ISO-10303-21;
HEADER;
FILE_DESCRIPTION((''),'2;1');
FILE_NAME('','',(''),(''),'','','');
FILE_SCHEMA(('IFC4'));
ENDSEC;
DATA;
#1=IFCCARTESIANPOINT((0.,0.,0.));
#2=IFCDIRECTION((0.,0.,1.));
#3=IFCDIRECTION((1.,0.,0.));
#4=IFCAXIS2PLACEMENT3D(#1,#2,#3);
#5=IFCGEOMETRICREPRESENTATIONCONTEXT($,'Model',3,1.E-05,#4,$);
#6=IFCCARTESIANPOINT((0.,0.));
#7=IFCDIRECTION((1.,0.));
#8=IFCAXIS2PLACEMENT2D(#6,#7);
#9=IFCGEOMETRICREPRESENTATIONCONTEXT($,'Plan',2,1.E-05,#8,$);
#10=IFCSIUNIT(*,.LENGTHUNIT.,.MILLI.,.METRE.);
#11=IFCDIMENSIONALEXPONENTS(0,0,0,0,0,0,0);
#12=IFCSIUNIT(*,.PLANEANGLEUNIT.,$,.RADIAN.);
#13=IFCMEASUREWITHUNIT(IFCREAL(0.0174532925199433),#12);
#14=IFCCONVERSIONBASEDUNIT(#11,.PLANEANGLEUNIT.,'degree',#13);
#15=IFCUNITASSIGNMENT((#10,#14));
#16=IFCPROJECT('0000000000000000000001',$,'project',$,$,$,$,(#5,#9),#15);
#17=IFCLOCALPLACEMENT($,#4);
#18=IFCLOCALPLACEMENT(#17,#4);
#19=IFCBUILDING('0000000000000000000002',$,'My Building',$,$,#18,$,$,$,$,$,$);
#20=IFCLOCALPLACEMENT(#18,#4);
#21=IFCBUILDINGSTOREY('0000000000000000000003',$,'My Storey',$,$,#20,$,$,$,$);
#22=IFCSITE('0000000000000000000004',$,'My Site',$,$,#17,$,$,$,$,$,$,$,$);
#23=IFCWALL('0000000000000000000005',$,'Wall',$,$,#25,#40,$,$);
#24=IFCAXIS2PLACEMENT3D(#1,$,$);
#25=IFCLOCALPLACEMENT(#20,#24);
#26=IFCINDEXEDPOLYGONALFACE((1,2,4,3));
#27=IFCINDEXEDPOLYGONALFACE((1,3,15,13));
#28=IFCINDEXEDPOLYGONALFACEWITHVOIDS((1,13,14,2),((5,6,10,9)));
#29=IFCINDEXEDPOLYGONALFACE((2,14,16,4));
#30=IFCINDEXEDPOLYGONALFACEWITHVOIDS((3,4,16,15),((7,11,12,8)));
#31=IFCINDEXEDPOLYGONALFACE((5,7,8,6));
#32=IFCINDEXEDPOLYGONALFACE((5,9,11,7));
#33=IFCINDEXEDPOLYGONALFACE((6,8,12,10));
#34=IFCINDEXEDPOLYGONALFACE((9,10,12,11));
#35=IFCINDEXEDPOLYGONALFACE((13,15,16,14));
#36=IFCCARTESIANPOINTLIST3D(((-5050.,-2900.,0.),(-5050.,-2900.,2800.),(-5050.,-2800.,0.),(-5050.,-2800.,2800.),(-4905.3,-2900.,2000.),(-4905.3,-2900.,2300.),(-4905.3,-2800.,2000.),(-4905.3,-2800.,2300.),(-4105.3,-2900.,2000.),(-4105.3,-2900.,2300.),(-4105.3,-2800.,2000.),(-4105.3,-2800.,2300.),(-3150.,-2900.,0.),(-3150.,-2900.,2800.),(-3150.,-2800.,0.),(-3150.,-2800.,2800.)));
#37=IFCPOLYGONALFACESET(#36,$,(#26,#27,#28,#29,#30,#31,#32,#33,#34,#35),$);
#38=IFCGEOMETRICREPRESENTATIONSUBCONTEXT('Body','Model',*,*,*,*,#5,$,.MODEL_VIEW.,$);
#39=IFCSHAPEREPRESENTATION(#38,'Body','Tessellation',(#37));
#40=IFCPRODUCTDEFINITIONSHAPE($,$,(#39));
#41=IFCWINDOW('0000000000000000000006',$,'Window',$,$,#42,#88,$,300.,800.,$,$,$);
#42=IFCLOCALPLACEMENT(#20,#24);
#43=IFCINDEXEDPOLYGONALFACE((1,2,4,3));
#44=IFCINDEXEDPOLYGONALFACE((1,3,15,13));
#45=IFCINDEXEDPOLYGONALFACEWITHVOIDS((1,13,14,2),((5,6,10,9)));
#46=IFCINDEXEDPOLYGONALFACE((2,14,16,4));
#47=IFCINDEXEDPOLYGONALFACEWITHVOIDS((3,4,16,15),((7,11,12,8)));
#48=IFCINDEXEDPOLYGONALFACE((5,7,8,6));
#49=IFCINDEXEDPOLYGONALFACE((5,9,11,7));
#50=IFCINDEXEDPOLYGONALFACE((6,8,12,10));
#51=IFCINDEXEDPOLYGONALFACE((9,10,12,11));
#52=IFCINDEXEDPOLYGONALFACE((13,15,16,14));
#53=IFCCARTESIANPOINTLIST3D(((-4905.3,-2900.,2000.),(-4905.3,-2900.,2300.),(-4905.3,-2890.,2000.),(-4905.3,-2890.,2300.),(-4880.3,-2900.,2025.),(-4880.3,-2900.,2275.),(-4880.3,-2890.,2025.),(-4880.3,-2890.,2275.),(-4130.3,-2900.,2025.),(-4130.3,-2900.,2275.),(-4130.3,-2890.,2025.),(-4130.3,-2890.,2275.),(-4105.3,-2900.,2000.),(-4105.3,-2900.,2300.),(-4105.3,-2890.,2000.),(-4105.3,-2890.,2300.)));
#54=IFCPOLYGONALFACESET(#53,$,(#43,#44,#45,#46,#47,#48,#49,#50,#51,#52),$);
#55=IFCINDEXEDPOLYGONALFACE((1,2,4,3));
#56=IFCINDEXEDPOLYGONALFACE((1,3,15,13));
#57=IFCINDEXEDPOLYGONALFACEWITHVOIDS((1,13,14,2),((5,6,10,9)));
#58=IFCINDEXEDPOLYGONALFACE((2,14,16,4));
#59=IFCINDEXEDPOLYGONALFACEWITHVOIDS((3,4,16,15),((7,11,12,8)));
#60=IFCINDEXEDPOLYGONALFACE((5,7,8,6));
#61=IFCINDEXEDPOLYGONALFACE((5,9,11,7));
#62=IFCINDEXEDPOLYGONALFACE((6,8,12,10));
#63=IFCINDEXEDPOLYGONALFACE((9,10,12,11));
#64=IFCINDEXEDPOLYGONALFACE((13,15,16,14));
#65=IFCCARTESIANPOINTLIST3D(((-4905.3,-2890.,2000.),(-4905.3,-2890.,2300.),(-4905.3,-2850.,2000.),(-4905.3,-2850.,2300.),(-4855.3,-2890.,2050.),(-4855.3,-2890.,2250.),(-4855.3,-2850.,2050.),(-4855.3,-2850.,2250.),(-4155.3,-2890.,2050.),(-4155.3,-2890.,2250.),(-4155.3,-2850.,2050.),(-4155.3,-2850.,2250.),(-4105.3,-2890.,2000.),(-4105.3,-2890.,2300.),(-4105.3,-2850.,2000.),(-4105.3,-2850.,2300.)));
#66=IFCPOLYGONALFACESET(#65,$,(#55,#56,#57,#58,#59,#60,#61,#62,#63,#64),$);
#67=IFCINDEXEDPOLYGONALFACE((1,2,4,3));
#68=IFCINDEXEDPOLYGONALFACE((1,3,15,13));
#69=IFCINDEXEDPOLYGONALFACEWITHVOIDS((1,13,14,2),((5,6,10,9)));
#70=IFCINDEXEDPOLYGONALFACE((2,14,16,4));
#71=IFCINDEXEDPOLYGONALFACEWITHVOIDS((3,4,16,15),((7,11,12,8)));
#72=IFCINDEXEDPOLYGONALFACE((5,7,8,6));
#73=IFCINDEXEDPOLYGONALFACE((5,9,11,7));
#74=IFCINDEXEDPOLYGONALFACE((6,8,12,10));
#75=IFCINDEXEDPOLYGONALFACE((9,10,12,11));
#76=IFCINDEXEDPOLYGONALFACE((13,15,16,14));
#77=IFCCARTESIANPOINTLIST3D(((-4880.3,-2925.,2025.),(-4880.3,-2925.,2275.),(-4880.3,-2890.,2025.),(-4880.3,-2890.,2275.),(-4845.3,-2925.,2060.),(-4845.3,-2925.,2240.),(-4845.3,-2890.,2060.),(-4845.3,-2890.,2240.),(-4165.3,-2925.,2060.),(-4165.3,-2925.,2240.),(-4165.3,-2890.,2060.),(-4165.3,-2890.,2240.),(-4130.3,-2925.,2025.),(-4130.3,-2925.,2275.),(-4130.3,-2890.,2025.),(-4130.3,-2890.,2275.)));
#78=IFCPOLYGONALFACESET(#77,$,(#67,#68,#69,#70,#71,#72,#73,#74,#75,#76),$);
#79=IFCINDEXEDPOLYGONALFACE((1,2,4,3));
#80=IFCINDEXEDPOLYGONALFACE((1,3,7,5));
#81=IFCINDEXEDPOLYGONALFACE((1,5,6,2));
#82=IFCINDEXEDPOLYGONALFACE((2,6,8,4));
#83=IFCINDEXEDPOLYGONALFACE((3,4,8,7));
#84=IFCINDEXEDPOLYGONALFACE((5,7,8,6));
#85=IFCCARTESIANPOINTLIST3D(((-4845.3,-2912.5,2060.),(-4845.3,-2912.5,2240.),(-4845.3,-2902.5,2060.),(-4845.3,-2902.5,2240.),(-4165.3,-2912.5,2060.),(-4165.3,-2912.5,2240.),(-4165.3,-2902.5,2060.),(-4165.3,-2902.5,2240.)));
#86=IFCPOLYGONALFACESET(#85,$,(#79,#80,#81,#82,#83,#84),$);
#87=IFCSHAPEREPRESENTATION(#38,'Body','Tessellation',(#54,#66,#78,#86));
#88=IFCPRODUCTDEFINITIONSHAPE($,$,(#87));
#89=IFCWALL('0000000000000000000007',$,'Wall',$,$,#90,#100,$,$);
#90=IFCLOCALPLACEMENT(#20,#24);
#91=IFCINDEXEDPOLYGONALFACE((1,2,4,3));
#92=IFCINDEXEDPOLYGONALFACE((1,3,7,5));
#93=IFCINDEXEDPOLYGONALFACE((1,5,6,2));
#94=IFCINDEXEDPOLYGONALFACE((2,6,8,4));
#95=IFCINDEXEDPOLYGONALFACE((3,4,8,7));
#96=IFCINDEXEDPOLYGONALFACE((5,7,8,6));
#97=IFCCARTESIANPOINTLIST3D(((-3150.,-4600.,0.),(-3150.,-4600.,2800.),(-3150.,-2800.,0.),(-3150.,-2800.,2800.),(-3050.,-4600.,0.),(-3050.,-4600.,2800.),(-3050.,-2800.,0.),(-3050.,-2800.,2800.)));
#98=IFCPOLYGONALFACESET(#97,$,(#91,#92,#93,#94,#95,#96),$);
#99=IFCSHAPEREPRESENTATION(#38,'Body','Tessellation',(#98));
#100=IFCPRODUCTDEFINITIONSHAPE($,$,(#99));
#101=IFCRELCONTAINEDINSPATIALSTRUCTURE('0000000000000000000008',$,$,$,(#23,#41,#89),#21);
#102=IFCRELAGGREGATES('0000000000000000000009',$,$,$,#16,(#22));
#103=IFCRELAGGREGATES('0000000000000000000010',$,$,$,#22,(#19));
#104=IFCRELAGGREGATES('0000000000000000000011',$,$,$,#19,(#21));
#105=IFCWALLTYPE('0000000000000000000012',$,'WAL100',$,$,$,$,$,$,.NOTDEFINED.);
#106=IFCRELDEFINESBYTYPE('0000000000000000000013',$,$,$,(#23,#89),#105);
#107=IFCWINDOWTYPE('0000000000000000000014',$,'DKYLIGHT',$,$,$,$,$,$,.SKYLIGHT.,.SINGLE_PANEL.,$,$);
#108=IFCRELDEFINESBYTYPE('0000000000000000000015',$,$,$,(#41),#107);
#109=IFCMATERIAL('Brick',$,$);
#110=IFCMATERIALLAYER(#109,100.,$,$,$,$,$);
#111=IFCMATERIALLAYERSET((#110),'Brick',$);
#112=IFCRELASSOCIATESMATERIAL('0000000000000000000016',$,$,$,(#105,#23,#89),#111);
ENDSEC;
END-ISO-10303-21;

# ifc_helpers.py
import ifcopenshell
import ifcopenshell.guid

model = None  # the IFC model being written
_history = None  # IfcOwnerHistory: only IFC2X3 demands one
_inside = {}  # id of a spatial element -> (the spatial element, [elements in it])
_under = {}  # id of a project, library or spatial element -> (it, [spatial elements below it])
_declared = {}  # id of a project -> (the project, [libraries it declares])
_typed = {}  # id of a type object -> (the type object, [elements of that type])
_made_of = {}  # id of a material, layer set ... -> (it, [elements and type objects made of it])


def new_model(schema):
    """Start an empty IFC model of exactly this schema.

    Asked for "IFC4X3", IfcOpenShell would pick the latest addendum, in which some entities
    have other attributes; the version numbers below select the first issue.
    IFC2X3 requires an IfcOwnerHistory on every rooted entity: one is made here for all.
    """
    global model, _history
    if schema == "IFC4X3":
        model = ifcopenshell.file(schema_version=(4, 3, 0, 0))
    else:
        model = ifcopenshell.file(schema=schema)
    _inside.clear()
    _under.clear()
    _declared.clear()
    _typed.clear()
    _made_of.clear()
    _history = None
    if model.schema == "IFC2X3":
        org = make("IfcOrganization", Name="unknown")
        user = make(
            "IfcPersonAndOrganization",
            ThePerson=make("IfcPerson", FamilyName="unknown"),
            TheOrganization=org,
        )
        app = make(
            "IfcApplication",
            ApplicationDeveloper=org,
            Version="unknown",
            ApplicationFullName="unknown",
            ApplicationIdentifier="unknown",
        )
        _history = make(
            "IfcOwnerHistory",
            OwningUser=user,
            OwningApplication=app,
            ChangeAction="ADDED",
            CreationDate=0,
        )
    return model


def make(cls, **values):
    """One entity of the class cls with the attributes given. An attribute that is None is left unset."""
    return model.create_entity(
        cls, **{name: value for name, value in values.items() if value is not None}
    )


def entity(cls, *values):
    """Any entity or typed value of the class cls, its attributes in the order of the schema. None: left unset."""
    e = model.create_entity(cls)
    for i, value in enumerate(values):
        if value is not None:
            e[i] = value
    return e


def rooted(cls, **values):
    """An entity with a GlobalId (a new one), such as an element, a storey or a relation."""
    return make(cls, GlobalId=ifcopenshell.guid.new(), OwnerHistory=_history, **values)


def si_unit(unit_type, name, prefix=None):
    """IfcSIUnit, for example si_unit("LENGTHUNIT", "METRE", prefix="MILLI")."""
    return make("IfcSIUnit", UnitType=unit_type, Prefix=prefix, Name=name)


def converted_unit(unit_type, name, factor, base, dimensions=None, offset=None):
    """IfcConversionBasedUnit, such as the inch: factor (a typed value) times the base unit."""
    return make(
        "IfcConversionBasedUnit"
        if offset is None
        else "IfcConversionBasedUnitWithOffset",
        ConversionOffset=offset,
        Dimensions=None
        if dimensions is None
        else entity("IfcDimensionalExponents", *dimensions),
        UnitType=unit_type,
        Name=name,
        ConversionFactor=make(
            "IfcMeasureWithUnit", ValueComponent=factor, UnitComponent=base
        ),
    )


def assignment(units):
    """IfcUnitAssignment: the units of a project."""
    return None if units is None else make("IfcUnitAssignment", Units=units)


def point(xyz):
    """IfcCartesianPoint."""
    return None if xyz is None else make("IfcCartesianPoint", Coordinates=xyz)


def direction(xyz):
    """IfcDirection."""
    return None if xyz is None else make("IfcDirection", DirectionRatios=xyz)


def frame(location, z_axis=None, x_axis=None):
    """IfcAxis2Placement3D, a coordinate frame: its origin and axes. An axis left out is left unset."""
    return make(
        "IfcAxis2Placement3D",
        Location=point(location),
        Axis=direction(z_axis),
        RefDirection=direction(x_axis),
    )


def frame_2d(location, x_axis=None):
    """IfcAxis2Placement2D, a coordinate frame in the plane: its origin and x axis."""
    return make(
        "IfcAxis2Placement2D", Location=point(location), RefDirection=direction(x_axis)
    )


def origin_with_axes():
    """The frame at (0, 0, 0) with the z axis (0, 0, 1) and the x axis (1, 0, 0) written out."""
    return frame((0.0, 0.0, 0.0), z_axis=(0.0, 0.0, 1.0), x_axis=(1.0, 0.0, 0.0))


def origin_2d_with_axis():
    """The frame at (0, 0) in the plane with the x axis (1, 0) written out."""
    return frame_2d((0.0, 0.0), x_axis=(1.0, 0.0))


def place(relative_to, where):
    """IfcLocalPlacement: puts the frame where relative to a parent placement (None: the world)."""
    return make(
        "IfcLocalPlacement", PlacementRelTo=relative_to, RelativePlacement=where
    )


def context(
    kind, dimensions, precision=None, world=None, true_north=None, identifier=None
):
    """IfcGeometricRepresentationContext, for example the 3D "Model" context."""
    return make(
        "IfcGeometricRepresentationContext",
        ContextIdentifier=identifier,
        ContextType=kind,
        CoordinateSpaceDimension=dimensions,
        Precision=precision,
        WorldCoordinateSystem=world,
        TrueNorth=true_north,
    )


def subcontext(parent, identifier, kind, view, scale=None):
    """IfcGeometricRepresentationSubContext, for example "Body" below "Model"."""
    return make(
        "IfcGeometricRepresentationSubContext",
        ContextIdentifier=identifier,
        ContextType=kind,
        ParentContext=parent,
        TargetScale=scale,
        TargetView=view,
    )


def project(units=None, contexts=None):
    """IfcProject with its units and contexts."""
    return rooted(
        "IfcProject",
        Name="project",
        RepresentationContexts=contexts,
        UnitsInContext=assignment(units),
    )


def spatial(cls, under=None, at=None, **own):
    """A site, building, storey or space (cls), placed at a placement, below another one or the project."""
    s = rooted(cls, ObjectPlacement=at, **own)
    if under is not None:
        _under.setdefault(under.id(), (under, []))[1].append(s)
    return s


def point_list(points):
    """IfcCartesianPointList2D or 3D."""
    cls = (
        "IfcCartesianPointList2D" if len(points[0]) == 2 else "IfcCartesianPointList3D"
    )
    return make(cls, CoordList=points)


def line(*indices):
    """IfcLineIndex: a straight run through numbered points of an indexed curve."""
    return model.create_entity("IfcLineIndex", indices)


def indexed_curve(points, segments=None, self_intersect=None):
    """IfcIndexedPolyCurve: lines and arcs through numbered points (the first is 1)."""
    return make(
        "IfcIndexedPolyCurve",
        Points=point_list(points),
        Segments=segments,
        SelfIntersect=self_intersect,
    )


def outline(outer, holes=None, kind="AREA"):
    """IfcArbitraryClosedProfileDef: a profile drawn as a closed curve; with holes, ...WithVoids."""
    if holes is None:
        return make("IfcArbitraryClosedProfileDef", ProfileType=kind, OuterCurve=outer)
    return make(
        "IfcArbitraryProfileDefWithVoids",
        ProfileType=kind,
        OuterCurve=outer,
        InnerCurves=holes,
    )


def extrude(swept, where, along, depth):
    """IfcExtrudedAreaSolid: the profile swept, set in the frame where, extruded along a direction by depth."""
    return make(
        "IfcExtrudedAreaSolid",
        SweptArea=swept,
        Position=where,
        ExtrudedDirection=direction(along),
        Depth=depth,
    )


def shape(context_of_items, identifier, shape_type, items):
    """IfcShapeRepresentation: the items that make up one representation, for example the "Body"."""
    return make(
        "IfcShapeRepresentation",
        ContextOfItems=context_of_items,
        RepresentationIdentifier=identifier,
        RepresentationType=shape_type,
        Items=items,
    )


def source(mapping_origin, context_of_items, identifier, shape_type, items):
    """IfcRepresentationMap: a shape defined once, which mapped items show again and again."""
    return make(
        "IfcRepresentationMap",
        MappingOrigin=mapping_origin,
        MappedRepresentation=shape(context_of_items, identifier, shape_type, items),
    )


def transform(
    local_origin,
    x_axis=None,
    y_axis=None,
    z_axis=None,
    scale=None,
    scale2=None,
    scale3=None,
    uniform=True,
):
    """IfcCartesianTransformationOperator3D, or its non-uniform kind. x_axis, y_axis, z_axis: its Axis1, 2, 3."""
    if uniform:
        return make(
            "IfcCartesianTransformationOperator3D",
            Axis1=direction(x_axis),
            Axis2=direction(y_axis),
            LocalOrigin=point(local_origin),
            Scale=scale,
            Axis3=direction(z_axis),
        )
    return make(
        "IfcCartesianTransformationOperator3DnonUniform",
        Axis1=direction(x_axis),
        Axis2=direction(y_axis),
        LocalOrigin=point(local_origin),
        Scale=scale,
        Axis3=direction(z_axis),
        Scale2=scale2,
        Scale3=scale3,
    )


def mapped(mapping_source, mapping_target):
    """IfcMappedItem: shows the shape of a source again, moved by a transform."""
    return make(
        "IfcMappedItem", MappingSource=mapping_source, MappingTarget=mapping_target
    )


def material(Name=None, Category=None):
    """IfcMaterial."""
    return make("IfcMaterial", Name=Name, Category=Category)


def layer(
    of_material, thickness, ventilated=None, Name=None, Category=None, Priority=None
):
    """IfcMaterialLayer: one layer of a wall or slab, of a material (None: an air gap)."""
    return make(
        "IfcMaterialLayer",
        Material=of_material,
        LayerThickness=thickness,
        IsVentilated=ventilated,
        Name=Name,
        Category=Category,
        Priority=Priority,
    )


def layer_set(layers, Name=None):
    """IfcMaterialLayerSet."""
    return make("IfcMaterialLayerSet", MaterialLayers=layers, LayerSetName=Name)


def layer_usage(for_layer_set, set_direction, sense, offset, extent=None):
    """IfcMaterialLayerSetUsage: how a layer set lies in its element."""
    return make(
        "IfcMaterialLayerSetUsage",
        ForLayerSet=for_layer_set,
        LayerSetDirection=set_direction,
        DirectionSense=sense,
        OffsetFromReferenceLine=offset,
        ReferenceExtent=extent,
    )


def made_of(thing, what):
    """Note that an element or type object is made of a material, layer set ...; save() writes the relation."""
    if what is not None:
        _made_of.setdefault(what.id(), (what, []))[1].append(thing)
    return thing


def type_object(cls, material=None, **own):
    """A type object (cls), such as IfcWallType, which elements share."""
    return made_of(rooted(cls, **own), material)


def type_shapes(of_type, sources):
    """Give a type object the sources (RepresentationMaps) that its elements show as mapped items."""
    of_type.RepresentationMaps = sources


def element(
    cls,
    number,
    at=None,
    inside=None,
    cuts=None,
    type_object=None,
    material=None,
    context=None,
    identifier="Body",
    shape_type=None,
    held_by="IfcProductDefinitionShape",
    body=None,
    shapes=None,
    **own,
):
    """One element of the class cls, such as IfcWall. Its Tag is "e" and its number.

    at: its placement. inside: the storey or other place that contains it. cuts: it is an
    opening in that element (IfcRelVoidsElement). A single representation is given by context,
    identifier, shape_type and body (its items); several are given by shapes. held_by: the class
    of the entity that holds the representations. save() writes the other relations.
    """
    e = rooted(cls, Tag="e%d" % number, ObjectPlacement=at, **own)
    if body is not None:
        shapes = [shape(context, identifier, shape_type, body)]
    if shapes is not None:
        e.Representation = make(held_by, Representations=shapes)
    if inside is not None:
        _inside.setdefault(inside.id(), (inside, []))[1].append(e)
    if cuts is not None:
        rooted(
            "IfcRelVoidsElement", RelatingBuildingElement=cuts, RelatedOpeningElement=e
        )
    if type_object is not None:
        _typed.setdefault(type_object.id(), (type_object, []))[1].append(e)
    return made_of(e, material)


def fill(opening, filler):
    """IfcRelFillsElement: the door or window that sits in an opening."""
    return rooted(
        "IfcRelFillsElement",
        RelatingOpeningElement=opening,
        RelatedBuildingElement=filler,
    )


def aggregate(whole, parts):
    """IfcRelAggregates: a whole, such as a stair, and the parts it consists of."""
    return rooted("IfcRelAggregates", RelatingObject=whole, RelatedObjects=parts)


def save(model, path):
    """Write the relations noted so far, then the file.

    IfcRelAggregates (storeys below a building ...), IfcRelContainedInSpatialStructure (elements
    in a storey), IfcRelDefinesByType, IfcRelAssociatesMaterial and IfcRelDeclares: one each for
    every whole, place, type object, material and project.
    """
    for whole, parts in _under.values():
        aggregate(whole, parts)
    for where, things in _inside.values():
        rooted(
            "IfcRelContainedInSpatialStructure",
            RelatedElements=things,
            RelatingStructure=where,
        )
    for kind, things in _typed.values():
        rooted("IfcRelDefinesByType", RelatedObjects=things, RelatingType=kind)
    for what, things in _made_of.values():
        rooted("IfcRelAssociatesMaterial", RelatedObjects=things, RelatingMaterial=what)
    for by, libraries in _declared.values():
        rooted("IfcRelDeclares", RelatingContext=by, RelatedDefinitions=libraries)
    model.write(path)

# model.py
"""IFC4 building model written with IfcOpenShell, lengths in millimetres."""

from ifc_helpers import new_model, entity, si_unit, converted_unit, frame, origin_with_axes, origin_2d_with_axis, place, context, subcontext, project, spatial, line, indexed_curve, outline, extrude, shape, source, transform, mapped, material, layer, layer_set, layer_usage, type_object, type_shapes, element, fill, save


model = new_model("IFC4")

# Units and contexts
model_context = context("Model", 3, precision=1e-05, world=origin_with_axes())
plan_context = context("Plan", 2, precision=1e-05, world=origin_2d_with_axis())
body_context_1 = subcontext(model_context, "Body", "Model", "MODEL_VIEW")
body_context_2 = subcontext(plan_context, "Body", "Plan", "PLAN_VIEW")
ifc_project = project(units=[si_unit("LENGTHUNIT", "METRE", prefix="MILLI"), converted_unit("PLANEANGLEUNIT", "degree", entity("IfcReal", 0.0174532925199433), si_unit("PLANEANGLEUNIT", "RADIAN"), dimensions=[0, 0, 0, 0, 0, 0, 0])], contexts=[model_context, plan_context])

# Site, building, storey
site_placement = place(None, origin_with_axes())
site = spatial("IfcSite", under=ifc_project, at=site_placement, Name="My Site")
building_placement = place(site_placement, origin_with_axes())
building = spatial("IfcBuilding", under=site, at=building_placement, Name="My Building")
storey_placement = place(building_placement, origin_with_axes())
storey = spatial("IfcBuildingStorey", under=building, at=storey_placement, Name="My Storey")

# Shared definitions
ifc_material = material(Name="Brick")
ifc_layer_1 = layer(ifc_material, 100.0)
ifc_layer_set_1 = layer_set([ifc_layer_1], Name="Brick")
wall_type = type_object("IfcWallType", Name="WAL100", PredefinedType="NOTDEFINED", material=ifc_layer_set_1)

# Wall, opening, window
ifc_layer_usage_1 = layer_usage(ifc_layer_set_1, "AXIS2", "POSITIVE", 0.0)
wall_1_placement = place(storey_placement, frame((-3150.0, -2800.0, 0.0), z_axis=(0.0, 0.0, 1.0), x_axis=(-1.0, 0.000001, 0.0)))
wall_1 = element("IfcWall", 1, at=wall_1_placement, inside=storey, type_object=wall_type, material=ifc_layer_usage_1, Name="Wall", context=body_context_1, shape_type="SweptSolid", body=[
    extrude(outline(indexed_curve([(0.0, 0.0), (0.0, 100.0), (1900.0, 100.0), (1900.0, 0.0), (0.0, 0.0)], self_intersect=False)), origin_with_axes(), (0.0, 0.0, 1.0), 2800.0),
])
shared_shape_1 = source(origin_with_axes(), body_context_1, "Body", "SweptSolid", [
    extrude(outline(indexed_curve([(0.0, 0.0), (800.0, 0.0), (800.0, 300.0), (0.0, 300.0)], segments=[line(1, 2, 3, 4, 1)])), frame((0.0, -100.0, 0.0), z_axis=(0.0, -1.0, 0.0), x_axis=(1.0, 0.0, 0.0)), (0.0, 0.0, -1.0), 300.0),
])
opening_1_placement = place(wall_1_placement, frame((955.4, 0.0, 2000.0), z_axis=(0.0, 0.0, 1.0), x_axis=(1.0, 0.0, 0.0)))
opening_1 = element("IfcOpeningElement", 2, at=opening_1_placement, cuts=wall_1, PredefinedType="OPENING", context=body_context_1, shape_type="MappedRepresentation", body=[
    mapped(shared_shape_1, transform((0.0, 0.0, 0.0), x_axis=(1.0, 0.0, 0.0), y_axis=(0.0, 1.0, 0.0), z_axis=(0.0, 0.0, 1.0), scale=1.0)),
])
window_type_1 = type_object("IfcWindowType", Name="DKYLIGHT", PartitioningType="SINGLE_PANEL", PredefinedType="SKYLIGHT")
shared_shape_2 = source(origin_with_axes(), body_context_1, "Body", "SweptSolid", [
    extrude(outline(indexed_curve([(0.0, 0.0), (800.0, 0.0), (800.0, 300.0), (0.0, 300.0)], segments=[line(1, 2, 3, 4, 1)]), holes=[indexed_curve([(25.0, 25.0), (775.0, 25.0), (775.0, 275.0), (25.0, 275.0)], segments=[line(1, 2, 3, 4, 1)])]), frame((0.0, 90.0, 0.0), z_axis=(0.0, -1.0, 0.0), x_axis=(1.0, 0.0, 0.0)), (0.0, 0.0, -1.0), 10.0),
    extrude(outline(indexed_curve([(0.0, 0.0), (800.0, 0.0), (800.0, 300.0), (0.0, 300.0)], segments=[line(1, 2, 3, 4, 1)]), holes=[indexed_curve([(50.0, 50.0), (750.0, 50.0), (750.0, 250.0), (50.0, 250.0)], segments=[line(1, 2, 3, 4, 1)])]), frame((0.0, 50.0, 0.0), z_axis=(0.0, -1.0, 0.0), x_axis=(1.0, 0.0, 0.0)), (0.0, 0.0, -1.0), 40.0),
    extrude(outline(indexed_curve([(0.0, 0.0), (750.0, 0.0), (750.0, 250.0), (0.0, 250.0)], segments=[line(1, 2, 3, 4, 1)]), holes=[indexed_curve([(35.0, 35.0), (715.0, 35.0), (715.0, 215.0), (35.0, 215.0)], segments=[line(1, 2, 3, 4, 1)])]), frame((25.0, 90.0, 25.0), z_axis=(0.0, -1.0, 0.0), x_axis=(1.0, 0.0, 0.0)), (0.0, 0.0, -1.0), 35.0),
    extrude(outline(indexed_curve([(35.0, 35.0), (715.0, 35.0), (715.0, 215.0), (35.0, 215.0)], segments=[line(1, 2, 3, 4, 1)])), frame((25.0, 102.5, 25.0), z_axis=(0.0, -1.0, 0.0), x_axis=(1.0, 0.0, 0.0)), (0.0, 0.0, -1.0), 10.0),
])
shared_shape_3 = source(origin_with_axes(), body_context_2, "Body", "Curve2D", [
    entity("IfcIndexedPolyCurve", entity("IfcCartesianPointList2D", [[50.0, 50.0], [750.0, 50.0]])),
    entity("IfcIndexedPolyCurve", entity("IfcCartesianPointList2D", [[0.0, 100.0], [25.0, 100.0], [25.0, 90.0], [50.0, 90.0], [50.0, 50.0], [0.0, 50.0]]), [entity("IfcLineIndex", [1, 2, 3, 4, 5, 6, 1])]),
    entity("IfcIndexedPolyCurve", entity("IfcCartesianPointList2D", [[800.0, 100.0], [775.0, 100.0], [775.0, 90.0], [750.0, 90.0], [750.0, 50.0], [800.0, 50.0]]), [entity("IfcLineIndex", [1, 2, 3, 4, 5, 6, 1])]),
    entity("IfcIndexedPolyCurve", entity("IfcCartesianPointList2D", [[25.0, 90.0], [60.0, 90.0], [60.0, 125.0], [25.0, 125.0]]), [entity("IfcLineIndex", [1, 2, 3, 4, 1])]),
    entity("IfcIndexedPolyCurve", entity("IfcCartesianPointList2D", [[775.0, 90.0], [740.0, 90.0], [740.0, 125.0], [775.0, 125.0]]), [entity("IfcLineIndex", [1, 2, 3, 4, 1])]),
    entity("IfcIndexedPolyCurve", entity("IfcCartesianPointList2D", [[60.0, 90.0], [740.0, 90.0]])),
    entity("IfcIndexedPolyCurve", entity("IfcCartesianPointList2D", [[60.0, 125.0], [740.0, 125.0]])),
    entity("IfcIndexedPolyCurve", entity("IfcCartesianPointList2D", [[60.0, 107.5], [740.0, 107.5]])),
])
type_shapes(window_type_1, [shared_shape_2, shared_shape_3])
window_1_placement = place(opening_1_placement, frame((0.0, 0.0, 0.0), z_axis=(0.0, 0.0, 1.0), x_axis=(1.0, 0.0, 0.0)))
window_1 = element("IfcWindow", 3, at=window_1_placement, inside=storey, type_object=window_type_1, Name="Window", OverallHeight=300.0, OverallWidth=800.0, shapes=[
    shape(body_context_1, "Body", "MappedRepresentation", [mapped(shared_shape_2, transform((0.0, 0.0, 0.0), x_axis=(1.0, 0.0, 0.0), y_axis=(0.0, 1.0, 0.0), z_axis=(0.0, 0.0, 1.0), scale=1.0))]),
    shape(body_context_2, "Body", "MappedRepresentation", [mapped(shared_shape_3, transform((0.0, 0.0, 0.0), x_axis=(1.0, 0.0, 0.0), y_axis=(0.0, 1.0, 0.0), z_axis=(0.0, 0.0, 1.0), scale=1.0))]),
])
fill(opening_1, window_1)

# Wall
ifc_layer_usage_2 = layer_usage(ifc_layer_set_1, "AXIS2", "POSITIVE", 0.0)
wall_2_placement = place(storey_placement, frame((-3050.0, -4600.0, 0.0), z_axis=(0.0, 0.0, 1.0), x_axis=(0.0, 1.0, 0.0)))
element("IfcWall", 4, at=wall_2_placement, inside=storey, type_object=wall_type, material=ifc_layer_usage_2, Name="Wall", context=body_context_1, shape_type="SweptSolid", body=[
    extrude(outline(indexed_curve([(0.0, 0.0), (0.0, 100.0), (1800.0, 100.0), (1800.0, 0.0), (0.0, 0.0)], self_intersect=False)), origin_with_axes(), (0.0, 0.0, 1.0), 2800.0),
])

save(model, "model.ifc")
